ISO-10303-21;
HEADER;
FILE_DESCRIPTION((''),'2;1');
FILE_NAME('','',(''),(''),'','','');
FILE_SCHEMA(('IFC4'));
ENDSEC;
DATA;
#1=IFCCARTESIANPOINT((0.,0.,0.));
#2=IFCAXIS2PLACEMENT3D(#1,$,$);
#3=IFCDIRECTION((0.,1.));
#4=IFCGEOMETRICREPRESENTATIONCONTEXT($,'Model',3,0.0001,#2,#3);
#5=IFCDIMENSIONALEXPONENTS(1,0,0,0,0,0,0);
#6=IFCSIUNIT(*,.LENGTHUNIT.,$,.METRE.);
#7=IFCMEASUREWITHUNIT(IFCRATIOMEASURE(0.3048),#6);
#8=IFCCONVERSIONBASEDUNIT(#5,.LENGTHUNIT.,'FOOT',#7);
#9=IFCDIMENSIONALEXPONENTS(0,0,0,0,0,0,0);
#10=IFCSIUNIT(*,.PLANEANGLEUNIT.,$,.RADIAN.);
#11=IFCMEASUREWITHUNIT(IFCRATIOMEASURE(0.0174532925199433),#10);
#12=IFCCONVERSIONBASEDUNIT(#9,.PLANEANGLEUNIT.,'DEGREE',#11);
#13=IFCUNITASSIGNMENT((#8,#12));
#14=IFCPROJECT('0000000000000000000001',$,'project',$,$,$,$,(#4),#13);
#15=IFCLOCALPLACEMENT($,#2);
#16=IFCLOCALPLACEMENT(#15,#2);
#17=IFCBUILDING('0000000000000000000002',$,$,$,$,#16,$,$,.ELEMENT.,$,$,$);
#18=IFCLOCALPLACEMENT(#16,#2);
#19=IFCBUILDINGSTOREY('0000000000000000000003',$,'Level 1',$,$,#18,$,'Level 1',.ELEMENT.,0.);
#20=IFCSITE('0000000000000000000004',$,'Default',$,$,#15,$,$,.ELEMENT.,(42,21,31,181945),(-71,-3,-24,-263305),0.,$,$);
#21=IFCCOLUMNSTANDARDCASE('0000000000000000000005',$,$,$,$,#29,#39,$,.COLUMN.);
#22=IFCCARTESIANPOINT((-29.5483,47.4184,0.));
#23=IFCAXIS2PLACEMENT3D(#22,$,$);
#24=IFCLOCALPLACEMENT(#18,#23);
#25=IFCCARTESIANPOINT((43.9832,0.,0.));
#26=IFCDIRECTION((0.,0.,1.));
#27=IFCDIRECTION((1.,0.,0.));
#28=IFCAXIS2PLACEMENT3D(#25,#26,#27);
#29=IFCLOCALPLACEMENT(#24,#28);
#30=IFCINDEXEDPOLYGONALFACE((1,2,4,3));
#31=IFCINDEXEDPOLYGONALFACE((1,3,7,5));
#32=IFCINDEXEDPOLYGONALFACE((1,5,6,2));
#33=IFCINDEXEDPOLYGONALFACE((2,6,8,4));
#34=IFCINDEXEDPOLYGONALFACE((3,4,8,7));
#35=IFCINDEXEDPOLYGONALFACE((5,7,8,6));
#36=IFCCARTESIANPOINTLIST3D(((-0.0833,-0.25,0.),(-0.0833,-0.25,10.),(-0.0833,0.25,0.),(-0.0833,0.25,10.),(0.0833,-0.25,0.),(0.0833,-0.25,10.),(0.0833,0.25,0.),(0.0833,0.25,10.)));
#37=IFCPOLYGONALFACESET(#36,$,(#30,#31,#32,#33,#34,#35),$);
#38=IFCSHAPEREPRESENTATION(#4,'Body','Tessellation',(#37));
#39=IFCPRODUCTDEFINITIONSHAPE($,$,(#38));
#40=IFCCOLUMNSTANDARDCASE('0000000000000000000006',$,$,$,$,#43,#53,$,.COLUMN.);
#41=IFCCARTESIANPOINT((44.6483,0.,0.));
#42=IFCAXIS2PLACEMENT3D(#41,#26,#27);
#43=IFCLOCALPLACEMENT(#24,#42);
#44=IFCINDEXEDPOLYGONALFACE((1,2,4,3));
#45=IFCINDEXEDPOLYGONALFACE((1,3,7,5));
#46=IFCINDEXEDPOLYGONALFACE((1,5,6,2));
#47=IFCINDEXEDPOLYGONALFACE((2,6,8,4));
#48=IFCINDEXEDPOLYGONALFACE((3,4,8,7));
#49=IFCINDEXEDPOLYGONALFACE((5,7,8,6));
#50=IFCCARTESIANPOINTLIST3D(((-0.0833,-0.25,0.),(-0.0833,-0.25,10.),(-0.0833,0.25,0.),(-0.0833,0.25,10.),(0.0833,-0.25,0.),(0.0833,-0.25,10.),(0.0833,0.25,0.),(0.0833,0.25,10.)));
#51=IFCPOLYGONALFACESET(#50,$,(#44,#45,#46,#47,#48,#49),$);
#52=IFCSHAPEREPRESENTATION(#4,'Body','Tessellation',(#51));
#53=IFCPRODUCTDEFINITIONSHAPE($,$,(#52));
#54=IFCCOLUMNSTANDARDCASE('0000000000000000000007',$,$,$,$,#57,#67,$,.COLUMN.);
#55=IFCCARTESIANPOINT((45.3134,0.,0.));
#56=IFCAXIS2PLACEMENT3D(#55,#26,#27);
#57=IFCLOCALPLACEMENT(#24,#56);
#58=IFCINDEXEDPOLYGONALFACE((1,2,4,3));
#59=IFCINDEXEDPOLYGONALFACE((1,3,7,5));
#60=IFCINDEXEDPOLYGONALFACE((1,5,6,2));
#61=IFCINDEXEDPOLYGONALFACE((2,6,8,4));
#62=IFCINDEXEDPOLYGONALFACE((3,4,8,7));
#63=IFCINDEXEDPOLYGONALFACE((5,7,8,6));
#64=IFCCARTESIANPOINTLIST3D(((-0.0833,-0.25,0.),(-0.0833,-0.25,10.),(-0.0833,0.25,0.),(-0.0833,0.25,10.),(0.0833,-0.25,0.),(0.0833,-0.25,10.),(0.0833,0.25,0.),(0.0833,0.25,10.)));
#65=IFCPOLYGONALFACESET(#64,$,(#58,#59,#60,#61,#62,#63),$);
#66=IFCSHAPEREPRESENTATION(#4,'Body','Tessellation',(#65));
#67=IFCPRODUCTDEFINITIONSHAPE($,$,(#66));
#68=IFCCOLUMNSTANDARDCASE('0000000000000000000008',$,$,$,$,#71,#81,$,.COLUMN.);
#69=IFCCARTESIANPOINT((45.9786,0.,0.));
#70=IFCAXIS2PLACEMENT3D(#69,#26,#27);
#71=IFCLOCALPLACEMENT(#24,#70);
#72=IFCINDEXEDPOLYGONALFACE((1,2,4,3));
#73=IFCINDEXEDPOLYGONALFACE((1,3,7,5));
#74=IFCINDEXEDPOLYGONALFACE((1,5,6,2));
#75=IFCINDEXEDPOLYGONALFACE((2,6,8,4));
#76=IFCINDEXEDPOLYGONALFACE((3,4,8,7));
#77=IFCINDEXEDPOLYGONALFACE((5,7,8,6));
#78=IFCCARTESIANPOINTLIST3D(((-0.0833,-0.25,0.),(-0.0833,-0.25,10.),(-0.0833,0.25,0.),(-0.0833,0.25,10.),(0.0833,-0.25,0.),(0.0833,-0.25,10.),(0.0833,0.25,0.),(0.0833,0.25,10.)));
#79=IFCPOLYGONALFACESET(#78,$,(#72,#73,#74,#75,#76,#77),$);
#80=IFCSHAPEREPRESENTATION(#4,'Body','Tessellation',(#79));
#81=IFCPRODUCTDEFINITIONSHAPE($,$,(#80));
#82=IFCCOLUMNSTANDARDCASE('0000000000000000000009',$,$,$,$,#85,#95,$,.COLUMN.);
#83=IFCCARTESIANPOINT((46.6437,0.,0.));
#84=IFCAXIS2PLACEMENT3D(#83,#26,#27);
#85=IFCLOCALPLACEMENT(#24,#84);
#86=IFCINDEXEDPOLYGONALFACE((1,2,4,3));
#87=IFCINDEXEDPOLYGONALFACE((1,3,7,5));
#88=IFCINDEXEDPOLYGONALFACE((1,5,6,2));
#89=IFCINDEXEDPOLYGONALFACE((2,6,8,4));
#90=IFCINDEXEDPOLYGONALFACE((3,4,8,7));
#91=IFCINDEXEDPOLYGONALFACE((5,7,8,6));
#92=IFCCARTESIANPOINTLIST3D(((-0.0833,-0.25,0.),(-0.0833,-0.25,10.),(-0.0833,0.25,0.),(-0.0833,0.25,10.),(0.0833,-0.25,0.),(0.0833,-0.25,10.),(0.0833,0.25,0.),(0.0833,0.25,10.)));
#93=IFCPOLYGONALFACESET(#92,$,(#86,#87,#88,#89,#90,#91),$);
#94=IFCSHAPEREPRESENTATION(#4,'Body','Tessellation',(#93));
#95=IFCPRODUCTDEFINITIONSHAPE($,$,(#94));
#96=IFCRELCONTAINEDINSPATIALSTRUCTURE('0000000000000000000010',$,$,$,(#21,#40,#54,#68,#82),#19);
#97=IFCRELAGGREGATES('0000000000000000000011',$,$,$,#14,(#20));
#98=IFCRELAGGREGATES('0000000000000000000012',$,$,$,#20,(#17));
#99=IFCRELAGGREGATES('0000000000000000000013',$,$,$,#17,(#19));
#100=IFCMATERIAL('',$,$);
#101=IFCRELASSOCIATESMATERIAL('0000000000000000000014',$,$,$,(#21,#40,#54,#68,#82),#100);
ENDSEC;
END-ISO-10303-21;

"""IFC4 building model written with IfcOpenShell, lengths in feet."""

from ifc_helpers import new_model, entity, si_unit, converted_unit, direction, frame, origin, place, context, project, spatial, rectangle, extrude, material, element, save


model = new_model("IFC4")

# Units and contexts
model_context = context("Model", 3, precision=0.0001, world=origin(), true_north=direction((0.0, 1.0)))
ifc_project = project(units=[converted_unit("LENGTHUNIT", "FOOT", entity("IfcRatioMeasure", 0.3048), si_unit("LENGTHUNIT", "METRE"), dimensions=[1, 0, 0, 0, 0, 0, 0]), converted_unit("PLANEANGLEUNIT", "DEGREE", entity("IfcRatioMeasure", 0.0174532925199433), si_unit("PLANEANGLEUNIT", "RADIAN"), dimensions=[0, 0, 0, 0, 0, 0, 0])], contexts=[model_context])

# Site, building, storey
site_placement = place(None, origin())
site = spatial("IfcSite", under=ifc_project, at=site_placement, Name="Default", CompositionType="ELEMENT", RefLatitude=(42, 21, 31, 181945), RefLongitude=(-71, -3, -24, -263305), RefElevation=0.0)
building_placement = place(site_placement, origin())
building = spatial("IfcBuilding", under=site, at=building_placement, CompositionType="ELEMENT")
storey_placement = place(building_placement, origin())
storey = spatial("IfcBuildingStorey", under=building, at=storey_placement, Name="Level 1", LongName="Level 1", CompositionType="ELEMENT", Elevation=0.0)

# Columns
ifc_material = material(Name="")
placement = place(storey_placement, frame((-29.5483, 47.4184, 0.0)))
for number, where, z_axis, x_axis in (
    (1, (43.9832, 0.0, 0.0), (0.0, 0.0, 1.0), (1.0, 0.0, 0.0)),
    (2, (44.6483, 0.0, 0.0), (0.0, 0.0, 1.0), (1.0, 0.0, 0.0)),
    (3, (45.3134, 0.0, 0.0), (0.0, 0.0, 1.0), (1.0, 0.0, 0.0)),
    (4, (45.9786, 0.0, 0.0), (0.0, 0.0, 1.0), (1.0, 0.0, 0.0)),
    (5, (46.6437, 0.0, 0.0), (0.0, 0.0, 1.0), (1.0, 0.0, 0.0)),
):
    element("IfcColumnStandardCase", number, at=place(placement, frame(where, z_axis=z_axis, x_axis=x_axis)), inside=storey, material=ifc_material, PredefinedType="COLUMN", context=model_context, shape_type="SweptSolid", body=[
        extrude(rectangle(XDim=0.1667, YDim=0.5), origin(), (0.0, 0.0, 1.0), 10.0),
    ])

save(model, "model.ifc")
